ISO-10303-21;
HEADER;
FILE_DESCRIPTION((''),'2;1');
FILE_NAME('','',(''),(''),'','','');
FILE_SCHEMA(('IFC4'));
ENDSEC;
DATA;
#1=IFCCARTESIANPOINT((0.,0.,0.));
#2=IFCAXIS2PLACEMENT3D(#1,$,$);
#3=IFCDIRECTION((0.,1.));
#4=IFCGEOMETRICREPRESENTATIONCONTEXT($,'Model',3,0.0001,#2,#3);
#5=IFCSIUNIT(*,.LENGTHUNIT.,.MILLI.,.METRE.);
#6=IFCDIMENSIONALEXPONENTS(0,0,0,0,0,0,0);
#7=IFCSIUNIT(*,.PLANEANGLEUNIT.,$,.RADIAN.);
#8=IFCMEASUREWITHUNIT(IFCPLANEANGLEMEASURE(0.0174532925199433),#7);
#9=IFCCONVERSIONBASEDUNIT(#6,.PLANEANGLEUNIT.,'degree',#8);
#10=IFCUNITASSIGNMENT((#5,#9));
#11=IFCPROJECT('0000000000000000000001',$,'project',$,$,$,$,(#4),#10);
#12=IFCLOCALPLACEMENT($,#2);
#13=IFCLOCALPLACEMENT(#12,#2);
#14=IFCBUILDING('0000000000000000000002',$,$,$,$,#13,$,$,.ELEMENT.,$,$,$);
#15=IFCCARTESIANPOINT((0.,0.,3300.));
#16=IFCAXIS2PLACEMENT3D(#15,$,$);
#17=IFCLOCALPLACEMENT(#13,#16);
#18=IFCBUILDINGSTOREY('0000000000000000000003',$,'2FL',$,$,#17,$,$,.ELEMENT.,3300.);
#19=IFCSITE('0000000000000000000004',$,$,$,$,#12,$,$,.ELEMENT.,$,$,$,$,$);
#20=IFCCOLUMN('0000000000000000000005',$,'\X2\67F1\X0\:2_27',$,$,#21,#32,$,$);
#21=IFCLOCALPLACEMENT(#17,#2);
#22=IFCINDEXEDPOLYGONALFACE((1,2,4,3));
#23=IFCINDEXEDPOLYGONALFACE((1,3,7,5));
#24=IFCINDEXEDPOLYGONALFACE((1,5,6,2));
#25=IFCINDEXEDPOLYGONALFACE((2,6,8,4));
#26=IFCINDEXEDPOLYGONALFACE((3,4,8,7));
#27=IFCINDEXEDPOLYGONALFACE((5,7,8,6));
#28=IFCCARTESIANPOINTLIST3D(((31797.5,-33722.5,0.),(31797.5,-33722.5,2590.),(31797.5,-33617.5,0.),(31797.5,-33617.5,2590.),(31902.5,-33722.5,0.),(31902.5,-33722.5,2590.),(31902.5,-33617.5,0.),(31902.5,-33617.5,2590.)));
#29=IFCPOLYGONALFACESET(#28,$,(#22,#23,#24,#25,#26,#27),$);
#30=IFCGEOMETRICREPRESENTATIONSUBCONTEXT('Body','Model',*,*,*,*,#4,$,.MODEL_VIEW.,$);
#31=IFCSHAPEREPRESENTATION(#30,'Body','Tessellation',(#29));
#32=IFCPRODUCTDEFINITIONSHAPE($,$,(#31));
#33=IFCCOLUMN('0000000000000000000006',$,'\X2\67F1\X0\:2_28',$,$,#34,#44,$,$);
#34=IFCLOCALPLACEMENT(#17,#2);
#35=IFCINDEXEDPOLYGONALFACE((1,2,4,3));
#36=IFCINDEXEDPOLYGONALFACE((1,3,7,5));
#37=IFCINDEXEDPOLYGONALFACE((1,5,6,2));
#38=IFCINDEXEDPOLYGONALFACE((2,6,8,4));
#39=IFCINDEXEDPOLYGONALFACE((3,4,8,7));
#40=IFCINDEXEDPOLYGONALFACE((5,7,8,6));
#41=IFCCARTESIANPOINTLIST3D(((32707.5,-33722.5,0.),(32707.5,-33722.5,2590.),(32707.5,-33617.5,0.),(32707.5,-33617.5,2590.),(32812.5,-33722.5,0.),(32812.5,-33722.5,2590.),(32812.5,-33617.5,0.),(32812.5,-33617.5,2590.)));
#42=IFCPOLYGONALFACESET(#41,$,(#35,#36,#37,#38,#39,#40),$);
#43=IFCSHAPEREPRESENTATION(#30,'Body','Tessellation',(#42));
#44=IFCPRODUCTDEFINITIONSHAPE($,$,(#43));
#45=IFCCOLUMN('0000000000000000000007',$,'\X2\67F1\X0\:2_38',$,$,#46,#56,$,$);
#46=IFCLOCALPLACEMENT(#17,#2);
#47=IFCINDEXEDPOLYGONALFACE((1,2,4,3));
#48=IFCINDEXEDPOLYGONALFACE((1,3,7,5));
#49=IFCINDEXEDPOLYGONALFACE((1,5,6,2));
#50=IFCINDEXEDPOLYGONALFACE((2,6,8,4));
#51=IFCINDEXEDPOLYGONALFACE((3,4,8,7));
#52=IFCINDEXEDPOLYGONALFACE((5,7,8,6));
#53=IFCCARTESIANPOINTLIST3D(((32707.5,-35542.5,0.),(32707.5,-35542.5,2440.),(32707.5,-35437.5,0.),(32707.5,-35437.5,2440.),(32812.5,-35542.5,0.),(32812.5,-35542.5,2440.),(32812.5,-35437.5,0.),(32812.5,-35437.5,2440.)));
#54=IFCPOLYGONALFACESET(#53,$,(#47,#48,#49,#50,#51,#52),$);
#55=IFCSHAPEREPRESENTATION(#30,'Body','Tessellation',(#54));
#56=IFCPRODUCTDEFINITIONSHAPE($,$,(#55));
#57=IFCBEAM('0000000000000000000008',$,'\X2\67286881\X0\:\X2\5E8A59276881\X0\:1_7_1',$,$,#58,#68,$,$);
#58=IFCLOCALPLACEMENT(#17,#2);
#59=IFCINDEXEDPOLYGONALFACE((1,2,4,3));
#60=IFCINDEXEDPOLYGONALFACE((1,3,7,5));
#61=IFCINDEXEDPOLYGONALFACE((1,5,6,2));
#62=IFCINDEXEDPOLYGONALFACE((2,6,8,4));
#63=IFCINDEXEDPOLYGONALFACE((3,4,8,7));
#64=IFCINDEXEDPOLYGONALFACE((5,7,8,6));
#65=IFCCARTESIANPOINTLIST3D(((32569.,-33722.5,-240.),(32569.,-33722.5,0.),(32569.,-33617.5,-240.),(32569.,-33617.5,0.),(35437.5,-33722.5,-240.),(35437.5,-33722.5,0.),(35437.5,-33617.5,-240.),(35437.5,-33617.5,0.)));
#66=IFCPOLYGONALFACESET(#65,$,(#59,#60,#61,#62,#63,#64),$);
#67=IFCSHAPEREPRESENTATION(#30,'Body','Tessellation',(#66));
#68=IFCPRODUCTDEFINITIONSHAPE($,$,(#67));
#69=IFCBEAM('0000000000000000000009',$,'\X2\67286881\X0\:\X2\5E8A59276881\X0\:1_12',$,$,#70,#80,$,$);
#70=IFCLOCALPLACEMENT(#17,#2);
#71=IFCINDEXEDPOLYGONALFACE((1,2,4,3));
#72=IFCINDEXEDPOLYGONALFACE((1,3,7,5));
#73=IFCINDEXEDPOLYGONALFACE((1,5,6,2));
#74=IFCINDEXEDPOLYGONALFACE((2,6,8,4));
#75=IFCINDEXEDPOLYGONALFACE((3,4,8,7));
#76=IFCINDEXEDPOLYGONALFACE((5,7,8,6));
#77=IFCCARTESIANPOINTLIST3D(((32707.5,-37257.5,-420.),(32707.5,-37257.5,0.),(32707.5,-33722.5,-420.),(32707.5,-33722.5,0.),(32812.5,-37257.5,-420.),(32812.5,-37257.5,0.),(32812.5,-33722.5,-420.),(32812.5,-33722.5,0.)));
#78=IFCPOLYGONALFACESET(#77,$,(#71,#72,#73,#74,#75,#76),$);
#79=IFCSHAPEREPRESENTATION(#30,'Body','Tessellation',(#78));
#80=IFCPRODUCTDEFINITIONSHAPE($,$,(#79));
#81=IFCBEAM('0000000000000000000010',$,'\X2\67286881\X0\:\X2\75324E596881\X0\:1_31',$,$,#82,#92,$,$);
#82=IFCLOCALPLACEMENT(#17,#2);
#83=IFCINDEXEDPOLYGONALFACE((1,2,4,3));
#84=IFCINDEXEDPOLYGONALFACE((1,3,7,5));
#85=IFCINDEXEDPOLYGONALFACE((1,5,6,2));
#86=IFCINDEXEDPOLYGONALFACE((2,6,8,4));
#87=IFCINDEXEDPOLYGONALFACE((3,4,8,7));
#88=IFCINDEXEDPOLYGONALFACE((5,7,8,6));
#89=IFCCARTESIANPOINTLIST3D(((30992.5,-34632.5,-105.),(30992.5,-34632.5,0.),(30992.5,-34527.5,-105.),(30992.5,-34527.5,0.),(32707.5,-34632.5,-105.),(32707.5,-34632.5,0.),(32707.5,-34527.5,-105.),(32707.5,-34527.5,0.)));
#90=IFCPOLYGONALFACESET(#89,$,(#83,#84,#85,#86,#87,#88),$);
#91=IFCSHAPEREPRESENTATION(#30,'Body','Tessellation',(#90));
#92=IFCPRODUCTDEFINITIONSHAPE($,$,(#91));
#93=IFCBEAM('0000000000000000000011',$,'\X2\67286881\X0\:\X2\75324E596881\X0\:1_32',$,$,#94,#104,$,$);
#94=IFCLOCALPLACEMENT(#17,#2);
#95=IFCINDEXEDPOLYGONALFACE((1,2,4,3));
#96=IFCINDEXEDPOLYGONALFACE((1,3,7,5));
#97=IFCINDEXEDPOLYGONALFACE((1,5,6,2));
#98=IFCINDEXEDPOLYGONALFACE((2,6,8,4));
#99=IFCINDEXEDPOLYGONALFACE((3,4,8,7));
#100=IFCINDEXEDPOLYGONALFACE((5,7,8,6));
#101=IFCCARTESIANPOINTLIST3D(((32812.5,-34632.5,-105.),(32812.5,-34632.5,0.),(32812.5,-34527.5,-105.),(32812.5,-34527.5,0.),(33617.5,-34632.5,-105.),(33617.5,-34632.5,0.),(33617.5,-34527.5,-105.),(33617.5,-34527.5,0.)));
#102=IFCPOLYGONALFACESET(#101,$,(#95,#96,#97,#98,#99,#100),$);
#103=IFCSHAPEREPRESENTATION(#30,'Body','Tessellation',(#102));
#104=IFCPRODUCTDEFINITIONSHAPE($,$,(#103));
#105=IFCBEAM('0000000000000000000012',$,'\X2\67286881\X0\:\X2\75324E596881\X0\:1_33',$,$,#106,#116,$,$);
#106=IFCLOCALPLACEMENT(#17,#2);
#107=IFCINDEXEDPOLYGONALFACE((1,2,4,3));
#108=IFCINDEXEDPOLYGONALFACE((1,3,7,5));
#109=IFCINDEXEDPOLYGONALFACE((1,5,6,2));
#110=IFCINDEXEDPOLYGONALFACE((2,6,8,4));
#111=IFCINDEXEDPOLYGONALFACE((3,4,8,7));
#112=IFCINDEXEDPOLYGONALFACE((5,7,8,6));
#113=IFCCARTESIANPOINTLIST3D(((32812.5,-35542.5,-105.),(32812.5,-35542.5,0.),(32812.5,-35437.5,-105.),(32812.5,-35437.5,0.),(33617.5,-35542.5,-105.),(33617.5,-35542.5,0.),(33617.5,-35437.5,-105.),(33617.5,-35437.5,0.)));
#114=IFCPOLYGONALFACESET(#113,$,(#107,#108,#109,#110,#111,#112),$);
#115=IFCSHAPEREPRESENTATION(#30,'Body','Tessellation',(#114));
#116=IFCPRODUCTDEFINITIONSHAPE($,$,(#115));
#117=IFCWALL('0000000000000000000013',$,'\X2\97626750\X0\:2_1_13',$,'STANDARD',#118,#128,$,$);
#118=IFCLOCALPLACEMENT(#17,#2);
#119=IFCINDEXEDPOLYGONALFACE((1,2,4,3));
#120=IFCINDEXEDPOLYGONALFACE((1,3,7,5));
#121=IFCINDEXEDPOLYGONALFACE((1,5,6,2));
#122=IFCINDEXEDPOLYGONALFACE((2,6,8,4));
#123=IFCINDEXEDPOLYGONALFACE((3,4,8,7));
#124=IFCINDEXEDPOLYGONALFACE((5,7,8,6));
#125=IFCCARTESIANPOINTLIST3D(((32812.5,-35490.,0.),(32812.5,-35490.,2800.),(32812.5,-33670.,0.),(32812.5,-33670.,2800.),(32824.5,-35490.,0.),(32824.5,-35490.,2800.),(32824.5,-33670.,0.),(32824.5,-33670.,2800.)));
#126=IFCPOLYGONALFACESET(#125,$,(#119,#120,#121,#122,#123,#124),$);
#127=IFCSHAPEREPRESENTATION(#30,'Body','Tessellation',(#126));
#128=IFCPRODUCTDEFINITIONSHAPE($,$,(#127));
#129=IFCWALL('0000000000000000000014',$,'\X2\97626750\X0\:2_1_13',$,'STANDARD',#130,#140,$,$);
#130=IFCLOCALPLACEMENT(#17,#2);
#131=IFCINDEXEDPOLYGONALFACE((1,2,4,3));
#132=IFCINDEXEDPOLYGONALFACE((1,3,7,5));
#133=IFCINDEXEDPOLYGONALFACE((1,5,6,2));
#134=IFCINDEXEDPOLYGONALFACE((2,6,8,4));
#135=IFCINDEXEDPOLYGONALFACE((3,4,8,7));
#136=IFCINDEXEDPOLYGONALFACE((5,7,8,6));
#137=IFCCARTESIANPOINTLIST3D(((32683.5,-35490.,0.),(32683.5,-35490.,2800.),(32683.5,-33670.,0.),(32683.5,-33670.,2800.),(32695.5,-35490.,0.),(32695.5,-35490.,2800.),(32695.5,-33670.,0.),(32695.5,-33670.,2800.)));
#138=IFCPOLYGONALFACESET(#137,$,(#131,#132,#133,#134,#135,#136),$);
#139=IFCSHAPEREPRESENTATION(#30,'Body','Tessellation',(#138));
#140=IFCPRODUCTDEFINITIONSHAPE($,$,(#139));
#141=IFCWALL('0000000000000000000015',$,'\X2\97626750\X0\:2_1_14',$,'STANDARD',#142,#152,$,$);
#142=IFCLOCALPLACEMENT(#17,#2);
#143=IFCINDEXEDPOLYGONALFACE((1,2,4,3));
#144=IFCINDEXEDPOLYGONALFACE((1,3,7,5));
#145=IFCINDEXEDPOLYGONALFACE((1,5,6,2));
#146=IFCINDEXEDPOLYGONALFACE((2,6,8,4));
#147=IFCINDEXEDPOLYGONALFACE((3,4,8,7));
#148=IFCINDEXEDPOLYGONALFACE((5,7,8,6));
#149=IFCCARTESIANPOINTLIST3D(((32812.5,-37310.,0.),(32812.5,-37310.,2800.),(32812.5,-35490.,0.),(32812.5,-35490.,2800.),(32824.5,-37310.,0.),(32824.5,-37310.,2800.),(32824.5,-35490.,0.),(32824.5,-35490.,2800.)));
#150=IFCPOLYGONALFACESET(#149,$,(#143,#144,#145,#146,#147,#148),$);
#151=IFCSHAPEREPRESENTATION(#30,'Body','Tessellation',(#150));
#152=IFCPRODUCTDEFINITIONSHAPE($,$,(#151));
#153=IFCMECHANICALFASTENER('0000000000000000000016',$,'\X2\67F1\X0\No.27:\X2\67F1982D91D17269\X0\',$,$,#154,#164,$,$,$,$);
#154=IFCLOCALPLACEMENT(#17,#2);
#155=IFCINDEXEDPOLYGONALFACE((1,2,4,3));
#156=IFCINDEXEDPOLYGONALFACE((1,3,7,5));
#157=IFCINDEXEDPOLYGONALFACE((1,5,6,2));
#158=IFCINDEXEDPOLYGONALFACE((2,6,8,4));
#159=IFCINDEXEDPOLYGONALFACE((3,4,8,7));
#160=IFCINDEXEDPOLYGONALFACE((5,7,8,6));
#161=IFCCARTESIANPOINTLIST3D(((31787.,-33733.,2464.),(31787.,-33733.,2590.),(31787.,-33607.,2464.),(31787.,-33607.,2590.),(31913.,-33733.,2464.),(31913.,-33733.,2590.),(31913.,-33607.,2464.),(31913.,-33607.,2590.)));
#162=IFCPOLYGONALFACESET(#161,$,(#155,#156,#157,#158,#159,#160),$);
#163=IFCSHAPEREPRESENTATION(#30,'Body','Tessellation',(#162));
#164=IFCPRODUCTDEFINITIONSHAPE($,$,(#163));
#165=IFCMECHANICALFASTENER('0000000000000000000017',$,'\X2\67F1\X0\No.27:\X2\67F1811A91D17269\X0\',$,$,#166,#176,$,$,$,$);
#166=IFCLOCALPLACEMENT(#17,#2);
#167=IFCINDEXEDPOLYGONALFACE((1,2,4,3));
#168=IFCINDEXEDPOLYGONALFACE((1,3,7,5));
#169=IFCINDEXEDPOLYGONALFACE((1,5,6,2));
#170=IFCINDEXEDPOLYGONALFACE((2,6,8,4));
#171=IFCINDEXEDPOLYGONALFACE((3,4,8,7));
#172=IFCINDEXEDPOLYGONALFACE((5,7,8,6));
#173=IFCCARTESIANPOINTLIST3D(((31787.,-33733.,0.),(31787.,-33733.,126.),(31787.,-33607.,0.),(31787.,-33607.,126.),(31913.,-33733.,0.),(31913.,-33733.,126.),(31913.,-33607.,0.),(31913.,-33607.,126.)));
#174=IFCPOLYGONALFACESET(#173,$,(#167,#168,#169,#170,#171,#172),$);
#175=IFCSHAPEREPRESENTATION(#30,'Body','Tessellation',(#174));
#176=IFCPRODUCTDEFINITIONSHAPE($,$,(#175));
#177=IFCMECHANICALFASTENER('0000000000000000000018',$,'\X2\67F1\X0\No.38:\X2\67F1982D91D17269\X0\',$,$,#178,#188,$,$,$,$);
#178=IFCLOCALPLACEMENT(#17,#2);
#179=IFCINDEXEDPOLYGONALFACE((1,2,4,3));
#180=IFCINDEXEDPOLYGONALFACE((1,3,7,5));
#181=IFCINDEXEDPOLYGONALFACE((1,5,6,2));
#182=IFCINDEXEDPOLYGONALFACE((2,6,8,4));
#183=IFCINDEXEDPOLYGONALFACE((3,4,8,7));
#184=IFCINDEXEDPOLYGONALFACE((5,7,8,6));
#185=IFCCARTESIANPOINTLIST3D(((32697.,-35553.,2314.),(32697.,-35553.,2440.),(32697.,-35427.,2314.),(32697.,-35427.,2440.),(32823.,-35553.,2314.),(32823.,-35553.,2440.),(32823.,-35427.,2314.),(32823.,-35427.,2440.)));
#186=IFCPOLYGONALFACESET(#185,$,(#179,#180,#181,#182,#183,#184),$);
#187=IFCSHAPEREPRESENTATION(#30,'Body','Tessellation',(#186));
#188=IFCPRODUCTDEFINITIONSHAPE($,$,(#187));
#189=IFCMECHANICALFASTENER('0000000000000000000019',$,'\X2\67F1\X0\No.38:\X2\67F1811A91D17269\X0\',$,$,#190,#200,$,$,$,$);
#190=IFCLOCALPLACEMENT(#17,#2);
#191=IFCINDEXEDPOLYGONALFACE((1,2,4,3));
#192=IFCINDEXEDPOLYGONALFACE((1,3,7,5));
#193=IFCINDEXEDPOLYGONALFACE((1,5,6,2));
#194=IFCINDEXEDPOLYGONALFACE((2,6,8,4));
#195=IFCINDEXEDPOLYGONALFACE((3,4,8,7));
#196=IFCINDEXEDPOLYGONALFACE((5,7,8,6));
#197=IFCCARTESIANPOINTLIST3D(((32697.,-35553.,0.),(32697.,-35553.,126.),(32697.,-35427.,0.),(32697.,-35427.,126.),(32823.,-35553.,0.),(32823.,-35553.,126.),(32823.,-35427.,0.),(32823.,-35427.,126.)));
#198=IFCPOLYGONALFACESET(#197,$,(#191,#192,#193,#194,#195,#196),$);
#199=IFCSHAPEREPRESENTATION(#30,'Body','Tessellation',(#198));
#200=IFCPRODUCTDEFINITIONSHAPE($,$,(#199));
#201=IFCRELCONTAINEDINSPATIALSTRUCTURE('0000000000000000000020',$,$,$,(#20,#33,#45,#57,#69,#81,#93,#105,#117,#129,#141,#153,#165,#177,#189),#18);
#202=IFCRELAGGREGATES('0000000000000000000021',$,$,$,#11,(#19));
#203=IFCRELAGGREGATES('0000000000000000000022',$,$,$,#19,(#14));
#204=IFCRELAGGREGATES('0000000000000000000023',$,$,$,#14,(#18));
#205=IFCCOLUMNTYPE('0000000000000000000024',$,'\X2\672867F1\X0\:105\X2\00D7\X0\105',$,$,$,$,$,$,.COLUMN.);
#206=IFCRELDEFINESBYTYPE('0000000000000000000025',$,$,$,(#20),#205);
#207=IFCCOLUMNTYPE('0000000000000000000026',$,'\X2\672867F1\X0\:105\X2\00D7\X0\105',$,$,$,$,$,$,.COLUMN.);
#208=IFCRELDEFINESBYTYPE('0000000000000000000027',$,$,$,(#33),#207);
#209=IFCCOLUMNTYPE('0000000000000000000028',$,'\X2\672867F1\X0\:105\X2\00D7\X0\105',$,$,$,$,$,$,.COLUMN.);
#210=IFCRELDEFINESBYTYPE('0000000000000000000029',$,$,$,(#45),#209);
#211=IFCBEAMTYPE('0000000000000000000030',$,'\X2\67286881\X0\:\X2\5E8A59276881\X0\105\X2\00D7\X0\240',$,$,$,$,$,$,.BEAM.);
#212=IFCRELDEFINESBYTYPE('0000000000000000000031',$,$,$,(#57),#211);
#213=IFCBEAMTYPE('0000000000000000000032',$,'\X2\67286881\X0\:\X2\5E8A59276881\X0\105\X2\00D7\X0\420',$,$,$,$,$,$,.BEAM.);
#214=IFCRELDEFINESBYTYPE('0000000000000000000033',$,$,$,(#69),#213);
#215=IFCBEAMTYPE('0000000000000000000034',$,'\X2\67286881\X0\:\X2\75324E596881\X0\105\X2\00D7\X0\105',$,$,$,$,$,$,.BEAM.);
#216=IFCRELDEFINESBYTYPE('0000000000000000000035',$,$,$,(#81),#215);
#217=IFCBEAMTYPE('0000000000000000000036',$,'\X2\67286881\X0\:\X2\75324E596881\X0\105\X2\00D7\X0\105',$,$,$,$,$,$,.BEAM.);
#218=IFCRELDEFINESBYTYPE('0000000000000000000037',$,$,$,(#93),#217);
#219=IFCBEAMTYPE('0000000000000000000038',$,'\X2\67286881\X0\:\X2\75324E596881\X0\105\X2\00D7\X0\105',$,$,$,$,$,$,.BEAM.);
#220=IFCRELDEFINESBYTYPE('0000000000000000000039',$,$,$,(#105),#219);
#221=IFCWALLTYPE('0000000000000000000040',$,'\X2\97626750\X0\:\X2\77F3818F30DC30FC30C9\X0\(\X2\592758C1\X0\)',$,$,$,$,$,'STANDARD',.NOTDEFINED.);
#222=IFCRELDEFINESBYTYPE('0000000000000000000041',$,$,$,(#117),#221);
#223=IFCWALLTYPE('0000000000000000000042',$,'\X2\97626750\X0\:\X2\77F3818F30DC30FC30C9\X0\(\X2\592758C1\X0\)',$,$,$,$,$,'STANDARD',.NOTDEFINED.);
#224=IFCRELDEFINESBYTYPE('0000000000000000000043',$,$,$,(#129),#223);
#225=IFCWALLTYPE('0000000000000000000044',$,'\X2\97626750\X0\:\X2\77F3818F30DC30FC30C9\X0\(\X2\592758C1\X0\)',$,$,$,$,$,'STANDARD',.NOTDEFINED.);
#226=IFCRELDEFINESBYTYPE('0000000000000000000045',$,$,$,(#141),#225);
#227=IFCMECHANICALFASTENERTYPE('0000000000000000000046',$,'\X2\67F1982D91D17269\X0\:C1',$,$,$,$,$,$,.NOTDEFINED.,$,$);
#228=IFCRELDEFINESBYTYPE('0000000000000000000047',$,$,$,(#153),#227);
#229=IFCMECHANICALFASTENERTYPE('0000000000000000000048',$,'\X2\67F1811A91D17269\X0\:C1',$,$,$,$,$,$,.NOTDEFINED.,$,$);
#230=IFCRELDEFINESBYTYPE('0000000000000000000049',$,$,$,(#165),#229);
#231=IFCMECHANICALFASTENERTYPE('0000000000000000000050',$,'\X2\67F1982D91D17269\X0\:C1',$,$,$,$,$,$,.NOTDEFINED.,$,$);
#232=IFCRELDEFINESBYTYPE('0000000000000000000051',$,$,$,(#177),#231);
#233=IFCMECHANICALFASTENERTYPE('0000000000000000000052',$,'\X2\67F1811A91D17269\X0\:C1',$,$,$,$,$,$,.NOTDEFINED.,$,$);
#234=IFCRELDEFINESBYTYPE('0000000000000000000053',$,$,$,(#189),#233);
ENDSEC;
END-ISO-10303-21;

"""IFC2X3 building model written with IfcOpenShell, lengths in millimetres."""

from ifc_helpers import new_model, entity, si_unit, converted_unit, direction, frame, origin, origin_with_axes, origin_2d, place, context, subcontext, project, spatial, polyline, rectangle, outline, extrude, type_object, element, save


model = new_model("IFC2X3")

# Units and contexts
model_context = context("Model", 3, precision=0.0001, world=origin(), true_north=direction((0.0, 1.0)))
body_context = subcontext(model_context, "Body", "Model", "MODEL_VIEW")
ifc_project = project(units=[si_unit("LENGTHUNIT", "METRE", prefix="MILLI"), converted_unit("PLANEANGLEUNIT", "degree", entity("IfcPlaneAngleMeasure", 0.0174532925199433), si_unit("PLANEANGLEUNIT", "RADIAN"), dimensions=[0, 0, 0, 0, 0, 0, 0])], contexts=[model_context])

# Site, building, storey
site_placement = place(None, origin())
site = spatial("IfcSite", under=ifc_project, at=site_placement, CompositionType="ELEMENT")
building_placement = place(site_placement, origin())
building = spatial("IfcBuilding", under=site, at=building_placement, CompositionType="ELEMENT")
storey_placement = place(building_placement, frame((0.0, 0.0, 3300.0)))
storey = spatial("IfcBuildingStorey", under=building, at=storey_placement, Name="2FL", CompositionType="ELEMENT", Elevation=3300.0)

# Columns
column_type_1 = type_object("IfcColumnType", Name="木柱:105×105", PredefinedType="COLUMN")
column_1_placement = place(storey_placement, frame((31850.0, -33670.0, 0.0)))
element("IfcColumn", 1, at=column_1_placement, inside=storey, type_object=column_type_1, Name="柱:2_27", context=body_context, shape_type="SweptSolid", body=[
    extrude(rectangle(XDim=105.0, YDim=105.0, at=origin_2d()), origin_with_axes(), (0.0, 0.0, 1.0), 2590.0),
])
column_type_2 = type_object("IfcColumnType", Name="木柱:105×105", PredefinedType="COLUMN")
column_2_placement = place(storey_placement, frame((32760.0, -33670.0, 0.0)))
element("IfcColumn", 2, at=column_2_placement, inside=storey, type_object=column_type_2, Name="柱:2_28", context=body_context, shape_type="SweptSolid", body=[
    extrude(rectangle(XDim=105.0, YDim=105.0, at=origin_2d()), origin_with_axes(), (0.0, 0.0, 1.0), 2590.0),
])
column_type_3 = type_object("IfcColumnType", Name="木柱:105×105", PredefinedType="COLUMN")
column_3_placement = place(storey_placement, frame((32760.0, -35490.0, 0.0)))
element("IfcColumn", 3, at=column_3_placement, inside=storey, type_object=column_type_3, Name="柱:2_38", context=body_context, shape_type="SweptSolid", body=[
    extrude(rectangle(XDim=105.0, YDim=105.0, at=origin_2d()), origin_with_axes(), (0.0, 0.0, 1.0), 2440.0),
])

# Beams
beam_type_1 = type_object("IfcBeamType", Name="木梁:床大梁105×240", PredefinedType="BEAM")
beam_1_placement = place(storey_placement, frame((32569.0, -33670.0, -120.0), z_axis=(1.0, 0.0, 0.0), x_axis=(0.0, 1.0, 0.0)))
element("IfcBeam", 4, at=beam_1_placement, inside=storey, type_object=beam_type_1, Name="木梁:床大梁:1_7_1", context=body_context, shape_type="SweptSolid", body=[
    extrude(rectangle(XDim=105.0, YDim=240.0, at=origin_2d()), origin_with_axes(), (0.0, 0.0, 1.0), 2868.5),
])
beam_type_2 = type_object("IfcBeamType", Name="木梁:床大梁105×420", PredefinedType="BEAM")
beam_2_placement = place(storey_placement, frame((32760.0, -33722.5, -210.0), z_axis=(0.0, -1.0, 0.0), x_axis=(1.0, 0.0, 0.0)))
element("IfcBeam", 5, at=beam_2_placement, inside=storey, type_object=beam_type_2, Name="木梁:床大梁:1_12", context=body_context, shape_type="SweptSolid", body=[
    extrude(rectangle(XDim=105.0, YDim=420.0, at=origin_2d()), origin_with_axes(), (0.0, 0.0, 1.0), 3535.0),
])
beam_type_3 = type_object("IfcBeamType", Name="木梁:甲乙梁105×105", PredefinedType="BEAM")
beam_3_placement = place(storey_placement, frame((30992.5, -34580.0, -52.5), z_axis=(1.0, 0.0, 0.0), x_axis=(0.0, 1.0, 0.0)))
element("IfcBeam", 6, at=beam_3_placement, inside=storey, type_object=beam_type_3, Name="木梁:甲乙梁:1_31", context=body_context, shape_type="SweptSolid", body=[
    extrude(rectangle(XDim=105.0, YDim=105.0, at=origin_2d()), origin_with_axes(), (0.0, 0.0, 1.0), 1715.0),
])
beam_type_4 = type_object("IfcBeamType", Name="木梁:甲乙梁105×105", PredefinedType="BEAM")
beam_4_placement = place(storey_placement, frame((32812.5, -34580.0, -52.5), z_axis=(1.0, 0.0, 0.0), x_axis=(0.0, 1.0, 0.0)))
element("IfcBeam", 7, at=beam_4_placement, inside=storey, type_object=beam_type_4, Name="木梁:甲乙梁:1_32", context=body_context, shape_type="SweptSolid", body=[
    extrude(rectangle(XDim=105.0, YDim=105.0, at=origin_2d()), origin_with_axes(), (0.0, 0.0, 1.0), 805.0),
])
beam_type_5 = type_object("IfcBeamType", Name="木梁:甲乙梁105×105", PredefinedType="BEAM")
beam_5_placement = place(storey_placement, frame((32812.5, -35490.0, -52.5), z_axis=(1.0, 0.0, 0.0), x_axis=(0.0, 1.0, 0.0)))
element("IfcBeam", 8, at=beam_5_placement, inside=storey, type_object=beam_type_5, Name="木梁:甲乙梁:1_33", context=body_context, shape_type="SweptSolid", body=[
    extrude(rectangle(XDim=105.0, YDim=105.0, at=origin_2d()), origin_with_axes(), (0.0, 0.0, 1.0), 805.0),
])

# Walls
wall_type_1 = type_object("IfcWallType", Name="面材:石膏ボード(大壁)", ElementType="STANDARD", PredefinedType="NOTDEFINED")
wall_1_placement = place(storey_placement, frame((32824.5, -34580.0, 0.0), z_axis=(-1.0, 0.0, 0.0), x_axis=(0.0, -1.0, 0.0)))
element("IfcWall", 9, at=wall_1_placement, inside=storey, type_object=wall_type_1, Name="面材:2_1_13", ObjectType="STANDARD", context=body_context, shape_type="SweptSolid", body=[
    extrude(outline(polyline([(910.0, 0.0, 0.0), (-910.0, 0.0, 0.0), (-910.0, 2800.0, 0.0), (910.0, 2800.0, 0.0), (910.0, 0.0, 0.0)])), origin_with_axes(), (0.0, 0.0, 1.0), 12.0),
])
wall_type_2 = type_object("IfcWallType", Name="面材:石膏ボード(大壁)", ElementType="STANDARD", PredefinedType="NOTDEFINED")
wall_2_placement = place(storey_placement, frame((32695.5, -34580.0, 0.0), z_axis=(-1.0, 0.0, 0.0), x_axis=(0.0, -1.0, 0.0)))
element("IfcWall", 10, at=wall_2_placement, inside=storey, type_object=wall_type_2, Name="面材:2_1_13", ObjectType="STANDARD", context=body_context, shape_type="SweptSolid", body=[
    extrude(outline(polyline([(910.0, 0.0, 0.0), (-910.0, 0.0, 0.0), (-910.0, 2800.0, 0.0), (910.0, 2800.0, 0.0), (910.0, 0.0, 0.0)])), origin_with_axes(), (0.0, 0.0, 1.0), 12.0),
])
wall_type_3 = type_object("IfcWallType", Name="面材:石膏ボード(大壁)", ElementType="STANDARD", PredefinedType="NOTDEFINED")
wall_3_placement = place(storey_placement, frame((32824.5, -36400.0, 0.0), z_axis=(-1.0, 0.0, 0.0), x_axis=(0.0, -1.0, 0.0)))
element("IfcWall", 11, at=wall_3_placement, inside=storey, type_object=wall_type_3, Name="面材:2_1_14", ObjectType="STANDARD", context=body_context, shape_type="SweptSolid", body=[
    extrude(outline(polyline([(910.0, 0.0, 0.0), (-910.0, 0.0, 0.0), (-910.0, 2800.0, 0.0), (910.0, 2800.0, 0.0), (910.0, 0.0, 0.0)])), origin_with_axes(), (0.0, 0.0, 1.0), 12.0),
])

# Mechanical fasteners
mechanical_fastener_type_1 = type_object("IfcMechanicalFastenerType", Name="柱頭金物:C1")
mechanical_fastener_1_placement = place(storey_placement, frame((31850.0, -33670.0, 2464.0)))
element("IfcMechanicalFastener", 12, at=mechanical_fastener_1_placement, inside=storey, type_object=mechanical_fastener_type_1, Name="柱No.27:柱頭金物", context=body_context, shape_type="SweptSolid", body=[
    extrude(rectangle(XDim=126.0, YDim=126.0, at=origin_2d()), origin_with_axes(), (0.0, 0.0, 1.0), 126.0),
])
mechanical_fastener_type_2 = type_object("IfcMechanicalFastenerType", Name="柱脚金物:C1")
mechanical_fastener_2_placement = place(storey_placement, frame((31850.0, -33670.0, 0.0)))
element("IfcMechanicalFastener", 13, at=mechanical_fastener_2_placement, inside=storey, type_object=mechanical_fastener_type_2, Name="柱No.27:柱脚金物", context=body_context, shape_type="SweptSolid", body=[
    extrude(rectangle(XDim=126.0, YDim=126.0, at=origin_2d()), origin_with_axes(), (0.0, 0.0, 1.0), 126.0),
])
mechanical_fastener_type_3 = type_object("IfcMechanicalFastenerType", Name="柱頭金物:C1")
mechanical_fastener_3_placement = place(storey_placement, frame((32760.0, -35490.0, 2314.0)))
element("IfcMechanicalFastener", 14, at=mechanical_fastener_3_placement, inside=storey, type_object=mechanical_fastener_type_3, Name="柱No.38:柱頭金物", context=body_context, shape_type="SweptSolid", body=[
    extrude(rectangle(XDim=126.0, YDim=126.0, at=origin_2d()), origin_with_axes(), (0.0, 0.0, 1.0), 126.0),
])
mechanical_fastener_type_4 = type_object("IfcMechanicalFastenerType", Name="柱脚金物:C1")
mechanical_fastener_4_placement = place(storey_placement, frame((32760.0, -35490.0, 0.0)))
element("IfcMechanicalFastener", 15, at=mechanical_fastener_4_placement, inside=storey, type_object=mechanical_fastener_type_4, Name="柱No.38:柱脚金物", context=body_context, shape_type="SweptSolid", body=[
    extrude(rectangle(XDim=126.0, YDim=126.0, at=origin_2d()), origin_with_axes(), (0.0, 0.0, 1.0), 126.0),
])

save(model, "model.ifc")
